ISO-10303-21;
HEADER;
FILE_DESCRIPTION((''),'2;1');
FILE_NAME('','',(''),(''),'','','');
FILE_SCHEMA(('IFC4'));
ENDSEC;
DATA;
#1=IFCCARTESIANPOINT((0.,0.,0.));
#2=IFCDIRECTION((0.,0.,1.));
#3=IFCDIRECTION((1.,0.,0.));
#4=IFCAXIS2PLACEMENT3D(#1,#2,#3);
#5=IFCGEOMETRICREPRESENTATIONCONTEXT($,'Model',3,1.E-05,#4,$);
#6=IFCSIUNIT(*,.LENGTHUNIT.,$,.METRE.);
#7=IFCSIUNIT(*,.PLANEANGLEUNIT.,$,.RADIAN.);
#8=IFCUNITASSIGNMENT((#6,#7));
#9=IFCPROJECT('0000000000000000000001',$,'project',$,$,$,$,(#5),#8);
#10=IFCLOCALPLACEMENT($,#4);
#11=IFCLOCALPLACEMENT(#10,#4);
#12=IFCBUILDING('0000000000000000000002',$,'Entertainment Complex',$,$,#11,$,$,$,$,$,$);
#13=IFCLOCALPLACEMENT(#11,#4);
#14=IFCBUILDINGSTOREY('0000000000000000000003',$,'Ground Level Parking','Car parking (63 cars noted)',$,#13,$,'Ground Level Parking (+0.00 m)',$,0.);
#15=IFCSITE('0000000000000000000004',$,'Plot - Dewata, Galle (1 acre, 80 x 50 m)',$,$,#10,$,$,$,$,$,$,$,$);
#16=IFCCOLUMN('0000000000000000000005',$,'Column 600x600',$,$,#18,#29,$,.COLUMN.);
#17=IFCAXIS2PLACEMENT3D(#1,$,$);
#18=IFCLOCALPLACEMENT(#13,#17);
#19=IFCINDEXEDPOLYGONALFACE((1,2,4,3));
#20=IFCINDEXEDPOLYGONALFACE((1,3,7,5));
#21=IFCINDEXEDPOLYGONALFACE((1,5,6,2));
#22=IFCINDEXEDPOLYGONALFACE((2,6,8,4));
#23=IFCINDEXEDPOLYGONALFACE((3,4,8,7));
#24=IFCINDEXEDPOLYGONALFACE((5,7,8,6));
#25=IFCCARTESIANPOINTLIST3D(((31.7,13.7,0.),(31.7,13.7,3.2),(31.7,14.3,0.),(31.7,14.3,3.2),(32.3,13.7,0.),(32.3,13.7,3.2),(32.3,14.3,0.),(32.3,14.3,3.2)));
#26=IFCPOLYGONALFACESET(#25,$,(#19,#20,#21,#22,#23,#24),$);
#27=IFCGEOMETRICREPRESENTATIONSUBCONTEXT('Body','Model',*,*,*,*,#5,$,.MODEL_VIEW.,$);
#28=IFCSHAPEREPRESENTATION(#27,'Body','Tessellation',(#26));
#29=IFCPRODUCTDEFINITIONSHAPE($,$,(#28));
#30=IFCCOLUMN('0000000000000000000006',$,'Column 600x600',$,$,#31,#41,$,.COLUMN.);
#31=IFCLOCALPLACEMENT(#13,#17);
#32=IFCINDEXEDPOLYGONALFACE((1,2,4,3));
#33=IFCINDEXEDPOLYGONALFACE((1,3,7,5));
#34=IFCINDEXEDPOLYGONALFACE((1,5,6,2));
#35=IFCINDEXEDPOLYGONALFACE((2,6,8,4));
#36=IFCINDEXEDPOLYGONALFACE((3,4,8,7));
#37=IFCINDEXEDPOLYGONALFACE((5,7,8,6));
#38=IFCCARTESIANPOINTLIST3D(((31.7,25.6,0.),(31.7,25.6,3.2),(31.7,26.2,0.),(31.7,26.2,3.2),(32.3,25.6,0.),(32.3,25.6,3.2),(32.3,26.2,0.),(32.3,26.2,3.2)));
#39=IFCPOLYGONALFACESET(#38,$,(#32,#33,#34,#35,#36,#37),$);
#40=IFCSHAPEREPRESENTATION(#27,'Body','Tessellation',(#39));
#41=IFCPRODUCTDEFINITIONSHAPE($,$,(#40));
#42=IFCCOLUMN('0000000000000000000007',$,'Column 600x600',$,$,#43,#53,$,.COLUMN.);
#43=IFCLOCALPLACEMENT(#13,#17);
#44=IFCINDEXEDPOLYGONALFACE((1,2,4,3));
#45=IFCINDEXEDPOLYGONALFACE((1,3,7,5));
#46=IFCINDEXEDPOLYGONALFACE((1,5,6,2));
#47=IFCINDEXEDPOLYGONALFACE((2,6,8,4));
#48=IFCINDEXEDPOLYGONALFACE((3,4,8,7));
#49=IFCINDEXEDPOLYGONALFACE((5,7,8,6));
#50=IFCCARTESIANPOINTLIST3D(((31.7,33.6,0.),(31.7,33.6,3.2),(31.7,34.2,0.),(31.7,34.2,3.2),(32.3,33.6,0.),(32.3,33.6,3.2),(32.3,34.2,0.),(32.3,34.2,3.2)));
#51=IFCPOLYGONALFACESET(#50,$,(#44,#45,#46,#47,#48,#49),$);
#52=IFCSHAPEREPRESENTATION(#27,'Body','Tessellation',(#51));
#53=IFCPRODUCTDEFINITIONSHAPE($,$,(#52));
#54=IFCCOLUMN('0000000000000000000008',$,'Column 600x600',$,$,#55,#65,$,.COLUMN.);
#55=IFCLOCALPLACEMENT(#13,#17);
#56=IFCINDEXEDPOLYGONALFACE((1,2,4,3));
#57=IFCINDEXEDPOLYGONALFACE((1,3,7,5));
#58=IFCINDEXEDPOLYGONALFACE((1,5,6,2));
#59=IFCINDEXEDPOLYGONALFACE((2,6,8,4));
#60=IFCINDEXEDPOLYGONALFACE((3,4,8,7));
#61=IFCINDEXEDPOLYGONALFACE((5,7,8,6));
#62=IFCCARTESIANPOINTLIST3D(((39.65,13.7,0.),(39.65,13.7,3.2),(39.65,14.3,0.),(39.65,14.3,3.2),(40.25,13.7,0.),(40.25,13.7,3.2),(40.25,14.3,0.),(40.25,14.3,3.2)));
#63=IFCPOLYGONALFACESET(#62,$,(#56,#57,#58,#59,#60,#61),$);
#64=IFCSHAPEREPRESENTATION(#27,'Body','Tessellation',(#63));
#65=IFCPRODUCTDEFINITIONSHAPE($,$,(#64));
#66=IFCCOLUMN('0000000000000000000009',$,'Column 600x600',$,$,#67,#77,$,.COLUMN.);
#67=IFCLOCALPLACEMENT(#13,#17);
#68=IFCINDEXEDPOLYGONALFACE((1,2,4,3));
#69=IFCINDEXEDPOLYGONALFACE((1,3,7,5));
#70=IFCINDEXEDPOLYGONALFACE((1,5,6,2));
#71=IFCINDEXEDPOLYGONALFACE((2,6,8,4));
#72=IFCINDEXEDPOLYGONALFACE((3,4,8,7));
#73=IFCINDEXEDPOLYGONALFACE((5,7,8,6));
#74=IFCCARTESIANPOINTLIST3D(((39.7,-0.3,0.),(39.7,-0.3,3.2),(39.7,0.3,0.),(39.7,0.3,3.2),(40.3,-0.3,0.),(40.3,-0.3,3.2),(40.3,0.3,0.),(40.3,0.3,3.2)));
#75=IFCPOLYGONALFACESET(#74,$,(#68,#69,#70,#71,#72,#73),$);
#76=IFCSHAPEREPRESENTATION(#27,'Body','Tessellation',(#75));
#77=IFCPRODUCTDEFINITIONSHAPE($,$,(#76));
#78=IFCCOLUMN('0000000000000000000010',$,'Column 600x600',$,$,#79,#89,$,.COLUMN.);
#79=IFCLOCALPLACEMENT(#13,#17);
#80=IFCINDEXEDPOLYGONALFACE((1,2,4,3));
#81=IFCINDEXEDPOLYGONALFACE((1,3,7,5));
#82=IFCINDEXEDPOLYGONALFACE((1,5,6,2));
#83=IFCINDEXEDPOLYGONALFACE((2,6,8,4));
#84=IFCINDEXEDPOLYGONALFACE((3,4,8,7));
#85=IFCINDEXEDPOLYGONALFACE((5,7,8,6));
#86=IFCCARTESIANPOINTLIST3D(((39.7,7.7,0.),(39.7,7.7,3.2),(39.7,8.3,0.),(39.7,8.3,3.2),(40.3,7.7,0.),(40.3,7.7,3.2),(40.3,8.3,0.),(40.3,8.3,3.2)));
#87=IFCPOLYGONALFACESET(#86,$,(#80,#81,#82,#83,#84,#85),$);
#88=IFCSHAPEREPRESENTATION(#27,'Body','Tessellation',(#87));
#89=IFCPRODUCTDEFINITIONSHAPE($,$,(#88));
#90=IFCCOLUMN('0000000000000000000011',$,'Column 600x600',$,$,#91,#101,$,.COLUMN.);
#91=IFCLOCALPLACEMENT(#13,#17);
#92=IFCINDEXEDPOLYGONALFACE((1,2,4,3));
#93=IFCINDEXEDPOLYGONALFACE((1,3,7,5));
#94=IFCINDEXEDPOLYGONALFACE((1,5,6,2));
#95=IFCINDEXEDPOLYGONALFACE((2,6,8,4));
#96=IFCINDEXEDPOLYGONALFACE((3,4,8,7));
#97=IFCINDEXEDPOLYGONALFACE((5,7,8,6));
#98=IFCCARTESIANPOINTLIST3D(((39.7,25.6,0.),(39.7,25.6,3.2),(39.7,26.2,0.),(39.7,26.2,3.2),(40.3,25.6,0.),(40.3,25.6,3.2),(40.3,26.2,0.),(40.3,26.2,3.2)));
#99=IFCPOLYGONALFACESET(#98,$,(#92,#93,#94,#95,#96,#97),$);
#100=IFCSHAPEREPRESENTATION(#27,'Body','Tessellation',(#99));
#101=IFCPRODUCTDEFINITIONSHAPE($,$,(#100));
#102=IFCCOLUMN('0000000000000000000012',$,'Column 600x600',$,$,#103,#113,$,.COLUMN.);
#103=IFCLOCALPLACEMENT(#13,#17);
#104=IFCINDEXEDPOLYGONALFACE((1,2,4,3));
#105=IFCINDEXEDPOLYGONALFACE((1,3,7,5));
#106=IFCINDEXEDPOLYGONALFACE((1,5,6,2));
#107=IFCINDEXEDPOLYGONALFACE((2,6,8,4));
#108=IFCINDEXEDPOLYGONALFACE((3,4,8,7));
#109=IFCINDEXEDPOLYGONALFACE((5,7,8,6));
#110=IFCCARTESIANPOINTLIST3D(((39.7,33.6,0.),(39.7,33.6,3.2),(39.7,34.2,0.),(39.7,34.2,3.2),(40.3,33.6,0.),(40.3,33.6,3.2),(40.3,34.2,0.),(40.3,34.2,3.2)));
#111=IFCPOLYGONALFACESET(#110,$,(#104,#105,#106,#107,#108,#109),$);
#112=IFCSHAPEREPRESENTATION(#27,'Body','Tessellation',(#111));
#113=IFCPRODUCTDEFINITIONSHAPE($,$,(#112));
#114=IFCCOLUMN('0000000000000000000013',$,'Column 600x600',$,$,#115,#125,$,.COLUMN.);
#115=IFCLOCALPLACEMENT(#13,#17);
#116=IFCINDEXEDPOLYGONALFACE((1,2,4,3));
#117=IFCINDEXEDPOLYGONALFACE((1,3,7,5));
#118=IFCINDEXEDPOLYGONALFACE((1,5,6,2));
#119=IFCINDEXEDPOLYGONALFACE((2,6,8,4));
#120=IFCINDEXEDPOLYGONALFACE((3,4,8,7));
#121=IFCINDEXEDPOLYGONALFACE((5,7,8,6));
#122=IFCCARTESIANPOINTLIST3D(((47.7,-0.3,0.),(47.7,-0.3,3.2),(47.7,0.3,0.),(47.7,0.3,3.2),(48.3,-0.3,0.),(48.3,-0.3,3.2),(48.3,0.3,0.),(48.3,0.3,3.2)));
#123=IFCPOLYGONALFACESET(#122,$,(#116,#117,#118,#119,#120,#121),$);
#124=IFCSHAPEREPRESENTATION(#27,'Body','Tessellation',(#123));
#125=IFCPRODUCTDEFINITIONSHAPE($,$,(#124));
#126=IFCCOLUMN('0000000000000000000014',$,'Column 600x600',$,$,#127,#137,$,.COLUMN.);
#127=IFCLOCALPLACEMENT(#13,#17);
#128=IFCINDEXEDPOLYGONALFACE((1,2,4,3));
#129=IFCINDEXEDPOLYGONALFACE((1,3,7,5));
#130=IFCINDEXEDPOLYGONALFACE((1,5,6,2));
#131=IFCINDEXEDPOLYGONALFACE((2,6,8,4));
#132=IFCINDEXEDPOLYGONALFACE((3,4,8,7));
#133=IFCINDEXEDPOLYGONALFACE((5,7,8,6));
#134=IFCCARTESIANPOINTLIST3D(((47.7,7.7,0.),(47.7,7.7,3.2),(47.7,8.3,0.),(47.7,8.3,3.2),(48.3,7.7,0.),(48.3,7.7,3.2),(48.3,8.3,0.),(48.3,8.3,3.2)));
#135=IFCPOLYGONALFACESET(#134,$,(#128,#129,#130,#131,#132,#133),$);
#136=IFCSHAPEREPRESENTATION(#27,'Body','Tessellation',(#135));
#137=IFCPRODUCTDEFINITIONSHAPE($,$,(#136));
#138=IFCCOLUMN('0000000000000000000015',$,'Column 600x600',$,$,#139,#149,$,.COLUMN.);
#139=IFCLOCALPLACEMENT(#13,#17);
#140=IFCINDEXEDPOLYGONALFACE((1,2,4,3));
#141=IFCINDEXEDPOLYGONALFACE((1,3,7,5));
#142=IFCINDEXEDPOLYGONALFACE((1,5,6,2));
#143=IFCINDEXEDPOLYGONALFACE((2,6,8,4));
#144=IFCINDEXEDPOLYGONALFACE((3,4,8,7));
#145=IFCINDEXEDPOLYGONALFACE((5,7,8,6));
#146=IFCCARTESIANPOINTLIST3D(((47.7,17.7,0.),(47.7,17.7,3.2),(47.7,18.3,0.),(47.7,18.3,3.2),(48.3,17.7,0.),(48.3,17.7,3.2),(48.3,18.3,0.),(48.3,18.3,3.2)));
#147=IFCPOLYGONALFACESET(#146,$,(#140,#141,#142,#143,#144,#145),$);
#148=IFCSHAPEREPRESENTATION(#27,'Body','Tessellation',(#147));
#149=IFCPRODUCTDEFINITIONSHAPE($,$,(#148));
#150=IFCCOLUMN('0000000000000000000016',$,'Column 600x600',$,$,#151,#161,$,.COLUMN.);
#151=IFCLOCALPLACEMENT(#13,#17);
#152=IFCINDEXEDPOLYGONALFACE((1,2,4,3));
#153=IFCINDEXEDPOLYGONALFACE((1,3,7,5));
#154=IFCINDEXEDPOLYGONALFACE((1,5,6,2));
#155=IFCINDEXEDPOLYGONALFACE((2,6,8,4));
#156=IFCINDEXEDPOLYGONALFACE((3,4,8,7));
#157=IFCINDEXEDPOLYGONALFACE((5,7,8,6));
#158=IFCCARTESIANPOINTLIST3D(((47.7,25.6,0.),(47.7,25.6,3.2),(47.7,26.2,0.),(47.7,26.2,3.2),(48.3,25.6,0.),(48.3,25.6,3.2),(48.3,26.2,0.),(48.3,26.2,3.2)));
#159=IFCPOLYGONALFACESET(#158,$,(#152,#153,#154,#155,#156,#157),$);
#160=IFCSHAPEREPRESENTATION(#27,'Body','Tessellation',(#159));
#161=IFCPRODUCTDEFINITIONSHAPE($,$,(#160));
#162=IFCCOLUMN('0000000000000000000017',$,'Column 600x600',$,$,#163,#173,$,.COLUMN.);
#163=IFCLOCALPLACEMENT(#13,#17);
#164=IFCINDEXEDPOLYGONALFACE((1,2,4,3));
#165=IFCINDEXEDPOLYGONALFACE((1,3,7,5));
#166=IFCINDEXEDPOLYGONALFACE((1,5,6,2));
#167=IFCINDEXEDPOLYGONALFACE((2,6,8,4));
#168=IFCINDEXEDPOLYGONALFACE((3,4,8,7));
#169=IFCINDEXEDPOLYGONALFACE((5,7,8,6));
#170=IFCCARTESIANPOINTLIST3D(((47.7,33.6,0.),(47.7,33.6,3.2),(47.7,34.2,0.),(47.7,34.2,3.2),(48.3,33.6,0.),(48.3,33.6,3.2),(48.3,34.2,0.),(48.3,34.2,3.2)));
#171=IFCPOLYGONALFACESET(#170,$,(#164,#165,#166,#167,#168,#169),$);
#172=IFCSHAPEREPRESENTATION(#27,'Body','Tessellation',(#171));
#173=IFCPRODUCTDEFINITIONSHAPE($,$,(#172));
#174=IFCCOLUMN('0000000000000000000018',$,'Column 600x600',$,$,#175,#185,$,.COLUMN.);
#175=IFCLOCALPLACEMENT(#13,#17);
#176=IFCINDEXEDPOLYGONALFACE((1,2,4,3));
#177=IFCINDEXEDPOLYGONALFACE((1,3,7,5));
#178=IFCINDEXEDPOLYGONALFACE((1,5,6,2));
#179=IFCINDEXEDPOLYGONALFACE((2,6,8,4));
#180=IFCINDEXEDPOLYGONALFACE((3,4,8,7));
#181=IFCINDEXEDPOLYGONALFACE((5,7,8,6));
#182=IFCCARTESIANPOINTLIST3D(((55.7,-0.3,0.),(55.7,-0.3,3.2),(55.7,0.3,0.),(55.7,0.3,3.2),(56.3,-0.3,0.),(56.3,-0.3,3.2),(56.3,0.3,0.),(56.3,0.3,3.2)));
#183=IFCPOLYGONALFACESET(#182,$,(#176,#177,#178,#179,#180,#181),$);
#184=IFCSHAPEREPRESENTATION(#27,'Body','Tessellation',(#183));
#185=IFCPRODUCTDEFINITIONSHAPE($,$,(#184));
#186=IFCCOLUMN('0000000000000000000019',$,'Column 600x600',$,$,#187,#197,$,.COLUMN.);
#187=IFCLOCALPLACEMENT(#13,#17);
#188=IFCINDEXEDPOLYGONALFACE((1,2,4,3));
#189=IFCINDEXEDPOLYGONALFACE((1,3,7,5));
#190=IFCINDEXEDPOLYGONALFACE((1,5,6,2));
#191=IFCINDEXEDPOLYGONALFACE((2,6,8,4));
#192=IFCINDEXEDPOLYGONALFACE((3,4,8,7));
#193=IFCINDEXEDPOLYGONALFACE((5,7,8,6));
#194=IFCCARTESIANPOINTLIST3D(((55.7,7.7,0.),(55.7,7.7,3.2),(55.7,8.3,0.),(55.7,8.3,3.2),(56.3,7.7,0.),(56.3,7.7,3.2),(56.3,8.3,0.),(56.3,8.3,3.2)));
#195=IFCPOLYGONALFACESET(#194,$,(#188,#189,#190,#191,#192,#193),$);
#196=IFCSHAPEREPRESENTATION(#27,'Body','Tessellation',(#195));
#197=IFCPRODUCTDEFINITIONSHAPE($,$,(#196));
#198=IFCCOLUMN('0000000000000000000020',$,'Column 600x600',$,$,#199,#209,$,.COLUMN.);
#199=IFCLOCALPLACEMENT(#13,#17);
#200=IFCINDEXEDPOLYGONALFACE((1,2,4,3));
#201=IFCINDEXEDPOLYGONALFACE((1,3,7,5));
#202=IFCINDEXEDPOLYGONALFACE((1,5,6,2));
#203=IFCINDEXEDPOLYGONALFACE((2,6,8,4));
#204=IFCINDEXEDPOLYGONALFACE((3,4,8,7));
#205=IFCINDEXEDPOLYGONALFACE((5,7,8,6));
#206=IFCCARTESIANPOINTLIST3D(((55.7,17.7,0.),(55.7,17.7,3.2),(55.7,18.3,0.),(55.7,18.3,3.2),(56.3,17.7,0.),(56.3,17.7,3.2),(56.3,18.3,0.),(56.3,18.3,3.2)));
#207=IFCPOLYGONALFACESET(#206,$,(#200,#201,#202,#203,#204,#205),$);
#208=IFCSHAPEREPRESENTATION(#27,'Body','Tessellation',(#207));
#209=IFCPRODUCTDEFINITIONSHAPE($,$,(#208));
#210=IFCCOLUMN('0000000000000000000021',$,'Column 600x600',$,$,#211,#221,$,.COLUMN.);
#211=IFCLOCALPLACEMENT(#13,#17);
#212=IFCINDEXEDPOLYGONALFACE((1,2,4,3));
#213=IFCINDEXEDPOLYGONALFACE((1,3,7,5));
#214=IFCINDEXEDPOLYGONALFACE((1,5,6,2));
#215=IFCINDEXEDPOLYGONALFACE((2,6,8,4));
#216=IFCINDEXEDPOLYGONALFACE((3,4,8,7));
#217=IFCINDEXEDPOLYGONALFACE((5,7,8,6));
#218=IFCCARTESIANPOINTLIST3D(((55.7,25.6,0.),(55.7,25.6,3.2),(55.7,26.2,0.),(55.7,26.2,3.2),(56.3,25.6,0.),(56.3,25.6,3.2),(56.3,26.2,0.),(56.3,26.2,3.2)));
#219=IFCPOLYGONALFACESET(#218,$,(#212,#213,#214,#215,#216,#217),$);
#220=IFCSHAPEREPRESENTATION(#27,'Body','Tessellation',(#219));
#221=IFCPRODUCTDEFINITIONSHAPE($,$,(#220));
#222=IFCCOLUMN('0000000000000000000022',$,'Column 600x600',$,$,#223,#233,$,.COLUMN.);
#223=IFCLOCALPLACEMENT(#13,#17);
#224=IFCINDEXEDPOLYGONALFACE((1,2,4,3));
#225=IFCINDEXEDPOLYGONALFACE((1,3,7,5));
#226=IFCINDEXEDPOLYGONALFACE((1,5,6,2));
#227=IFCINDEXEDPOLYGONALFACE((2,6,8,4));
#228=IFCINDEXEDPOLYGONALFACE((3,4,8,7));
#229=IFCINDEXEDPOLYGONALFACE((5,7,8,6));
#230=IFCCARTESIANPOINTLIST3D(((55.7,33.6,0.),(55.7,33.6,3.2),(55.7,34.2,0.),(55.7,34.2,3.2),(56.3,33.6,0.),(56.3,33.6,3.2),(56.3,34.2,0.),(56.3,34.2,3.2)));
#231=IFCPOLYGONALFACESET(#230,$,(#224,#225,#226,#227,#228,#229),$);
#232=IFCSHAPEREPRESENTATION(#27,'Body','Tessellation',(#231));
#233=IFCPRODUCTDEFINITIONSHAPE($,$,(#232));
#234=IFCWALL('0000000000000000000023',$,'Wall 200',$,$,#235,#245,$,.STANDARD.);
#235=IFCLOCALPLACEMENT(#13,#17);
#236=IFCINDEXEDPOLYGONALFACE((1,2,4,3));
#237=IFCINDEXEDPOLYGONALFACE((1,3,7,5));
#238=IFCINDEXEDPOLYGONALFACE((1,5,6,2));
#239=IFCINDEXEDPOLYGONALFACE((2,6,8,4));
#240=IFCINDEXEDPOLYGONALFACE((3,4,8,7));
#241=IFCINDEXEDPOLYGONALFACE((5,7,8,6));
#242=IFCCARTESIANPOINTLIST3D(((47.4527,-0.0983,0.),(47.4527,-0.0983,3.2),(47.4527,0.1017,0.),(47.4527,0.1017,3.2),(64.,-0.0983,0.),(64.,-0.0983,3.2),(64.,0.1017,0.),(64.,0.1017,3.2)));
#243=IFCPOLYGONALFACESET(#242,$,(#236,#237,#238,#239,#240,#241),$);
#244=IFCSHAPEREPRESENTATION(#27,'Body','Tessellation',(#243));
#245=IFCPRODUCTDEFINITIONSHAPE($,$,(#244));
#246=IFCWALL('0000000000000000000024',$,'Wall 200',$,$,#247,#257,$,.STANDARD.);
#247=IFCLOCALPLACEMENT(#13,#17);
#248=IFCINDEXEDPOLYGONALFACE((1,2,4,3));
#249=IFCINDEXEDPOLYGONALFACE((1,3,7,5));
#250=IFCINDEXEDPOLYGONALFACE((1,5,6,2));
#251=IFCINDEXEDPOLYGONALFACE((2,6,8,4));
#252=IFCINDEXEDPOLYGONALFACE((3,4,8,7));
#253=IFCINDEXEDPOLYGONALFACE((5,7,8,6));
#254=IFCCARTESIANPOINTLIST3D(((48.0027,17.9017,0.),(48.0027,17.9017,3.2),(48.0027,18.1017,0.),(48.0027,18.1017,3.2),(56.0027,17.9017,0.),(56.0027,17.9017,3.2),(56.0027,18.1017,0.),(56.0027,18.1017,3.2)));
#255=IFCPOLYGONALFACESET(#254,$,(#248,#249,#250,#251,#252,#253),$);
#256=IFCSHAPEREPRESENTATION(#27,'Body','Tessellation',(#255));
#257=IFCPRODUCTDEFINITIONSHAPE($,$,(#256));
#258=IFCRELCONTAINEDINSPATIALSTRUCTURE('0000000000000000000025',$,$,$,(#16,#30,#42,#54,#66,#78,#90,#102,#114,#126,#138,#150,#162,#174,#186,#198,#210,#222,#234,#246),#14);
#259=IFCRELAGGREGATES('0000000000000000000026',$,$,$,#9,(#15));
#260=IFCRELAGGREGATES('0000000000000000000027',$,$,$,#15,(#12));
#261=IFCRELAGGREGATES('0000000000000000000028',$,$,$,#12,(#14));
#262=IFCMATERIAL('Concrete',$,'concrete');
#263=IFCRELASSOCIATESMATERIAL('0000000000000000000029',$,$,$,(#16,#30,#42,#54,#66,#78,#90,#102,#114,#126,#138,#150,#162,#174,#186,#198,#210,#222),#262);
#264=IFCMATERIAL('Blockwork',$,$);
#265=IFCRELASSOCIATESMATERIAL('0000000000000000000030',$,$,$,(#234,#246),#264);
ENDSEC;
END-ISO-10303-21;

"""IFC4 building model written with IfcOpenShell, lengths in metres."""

from ifc_helpers import new_model, si_unit, frame, origin_with_axes, place, context, subcontext, project, spatial, polyline, outline, extrude, material, element, save


model = new_model("IFC4")

# Units and contexts
model_context = context("Model", 3, precision=1e-05, world=origin_with_axes())
body_context = subcontext(model_context, "Body", "Model", "MODEL_VIEW")
ifc_project = project(units=[si_unit("LENGTHUNIT", "METRE"), si_unit("PLANEANGLEUNIT", "RADIAN")], contexts=[model_context])

# Site, building, storey
site_placement = place(None, origin_with_axes())
site = spatial("IfcSite", under=ifc_project, at=site_placement, Name="Plot - Dewata, Galle (1 acre, 80 x 50 m)")
building_placement = place(site_placement, origin_with_axes())
building = spatial("IfcBuilding", under=site, at=building_placement, Name="Entertainment Complex")
storey_placement = place(building_placement, origin_with_axes())
storey = spatial("IfcBuildingStorey", under=building, at=storey_placement, Name="Ground Level Parking", Description="Car parking (63 cars noted)", LongName="Ground Level Parking (+0.00 m)", Elevation=0.0)

# Columns
ifc_material_1 = material(Name="Concrete", Category="concrete")
for number, where, z_axis, x_axis, name in (
    (1, (32.0, 14.0, 0.0), (0.0, 0.0, 1.0), (1.0, 0.0, 0.0), "Column 600x600"),
    (2, (32.0, 25.9, 0.0), (0.0, 0.0, 1.0), (1.0, 0.0, 0.0), "Column 600x600"),
    (3, (32.0, 33.9, 0.0), (0.0, 0.0, 1.0), (1.0, 0.0, 0.0), "Column 600x600"),
    (4, (39.95, 14.0, 0.0), (0.0, 0.0, 1.0), (1.0, 0.0, 0.0), "Column 600x600"),
    (5, (40.0, 0.0, 0.0), (0.0, 0.0, 1.0), (1.0, 0.0, 0.0), "Column 600x600"),
    (6, (40.0, 8.0, 0.0), (0.0, 0.0, 1.0), (1.0, 0.0, 0.0), "Column 600x600"),
    (7, (40.0, 25.9, 0.0), (0.0, 0.0, 1.0), (1.0, 0.0, 0.0), "Column 600x600"),
    (8, (40.0, 33.9, 0.0), (0.0, 0.0, 1.0), (1.0, 0.0, 0.0), "Column 600x600"),
    (9, (48.0, 0.0, 0.0), (0.0, 0.0, 1.0), (1.0, 0.0, 0.0), "Column 600x600"),
    (10, (48.0, 8.0, 0.0), (0.0, 0.0, 1.0), (1.0, 0.0, 0.0), "Column 600x600"),
    (11, (48.0, 18.0, 0.0), (0.0, 0.0, 1.0), (1.0, 0.0, 0.0), "Column 600x600"),
    (12, (48.0, 25.9, 0.0), (0.0, 0.0, 1.0), (1.0, 0.0, 0.0), "Column 600x600"),
    (13, (48.0, 33.9, 0.0), (0.0, 0.0, 1.0), (1.0, 0.0, 0.0), "Column 600x600"),
    (14, (56.0, 0.0, 0.0), (0.0, 0.0, 1.0), (1.0, 0.0, 0.0), "Column 600x600"),
    (15, (56.0, 8.0, 0.0), (0.0, 0.0, 1.0), (1.0, 0.0, 0.0), "Column 600x600"),
    (16, (56.0, 18.0, 0.0), (0.0, 0.0, 1.0), (1.0, 0.0, 0.0), "Column 600x600"),
    (17, (56.0, 25.9, 0.0), (0.0, 0.0, 1.0), (1.0, 0.0, 0.0), "Column 600x600"),
    (18, (56.0, 33.9, 0.0), (0.0, 0.0, 1.0), (1.0, 0.0, 0.0), "Column 600x600"),
):
    element("IfcColumn", number, at=place(storey_placement, frame(where, z_axis=z_axis, x_axis=x_axis)), inside=storey, material=ifc_material_1, Name=name, PredefinedType="COLUMN", context=body_context, shape_type="SweptSolid", body=[
        extrude(outline(polyline([(-0.3, -0.3), (0.3, -0.3), (0.3, 0.3), (-0.3, 0.3), (-0.3, -0.3)])), origin_with_axes(), (0.0, 0.0, 1.0), 3.2),
    ])

# Walls
ifc_material_2 = material(Name="Blockwork")
wall_1_placement = place(storey_placement, frame((47.4527, 0.0017, 0.0), z_axis=(0.0, 0.0, 1.0), x_axis=(1.0, 0.0, 0.0)))
element("IfcWall", 19, at=wall_1_placement, inside=storey, material=ifc_material_2, Name="Wall 200", PredefinedType="STANDARD", context=body_context, shape_type="SweptSolid", body=[
    extrude(outline(polyline([(0.0, -0.1), (16.5473, -0.1), (16.5473, 0.1), (0.0, 0.1), (0.0, -0.1)])), origin_with_axes(), (0.0, 0.0, 1.0), 3.2),
])
for number, where, z_axis, x_axis, name in (
    (20, (48.0027, 18.0017, 0.0), (0.0, 0.0, 1.0), (1.0, 0.0, 0.0), "Wall 200"),
):
    element("IfcWall", number, at=place(storey_placement, frame(where, z_axis=z_axis, x_axis=x_axis)), inside=storey, material=ifc_material_2, Name=name, PredefinedType="STANDARD", context=body_context, shape_type="SweptSolid", body=[
        extrude(outline(polyline([(0.0, -0.1), (8.0, -0.1), (8.0, 0.1), (0.0, 0.1), (0.0, -0.1)])), origin_with_axes(), (0.0, 0.0, 1.0), 3.2),
    ])

save(model, "model.ifc")
